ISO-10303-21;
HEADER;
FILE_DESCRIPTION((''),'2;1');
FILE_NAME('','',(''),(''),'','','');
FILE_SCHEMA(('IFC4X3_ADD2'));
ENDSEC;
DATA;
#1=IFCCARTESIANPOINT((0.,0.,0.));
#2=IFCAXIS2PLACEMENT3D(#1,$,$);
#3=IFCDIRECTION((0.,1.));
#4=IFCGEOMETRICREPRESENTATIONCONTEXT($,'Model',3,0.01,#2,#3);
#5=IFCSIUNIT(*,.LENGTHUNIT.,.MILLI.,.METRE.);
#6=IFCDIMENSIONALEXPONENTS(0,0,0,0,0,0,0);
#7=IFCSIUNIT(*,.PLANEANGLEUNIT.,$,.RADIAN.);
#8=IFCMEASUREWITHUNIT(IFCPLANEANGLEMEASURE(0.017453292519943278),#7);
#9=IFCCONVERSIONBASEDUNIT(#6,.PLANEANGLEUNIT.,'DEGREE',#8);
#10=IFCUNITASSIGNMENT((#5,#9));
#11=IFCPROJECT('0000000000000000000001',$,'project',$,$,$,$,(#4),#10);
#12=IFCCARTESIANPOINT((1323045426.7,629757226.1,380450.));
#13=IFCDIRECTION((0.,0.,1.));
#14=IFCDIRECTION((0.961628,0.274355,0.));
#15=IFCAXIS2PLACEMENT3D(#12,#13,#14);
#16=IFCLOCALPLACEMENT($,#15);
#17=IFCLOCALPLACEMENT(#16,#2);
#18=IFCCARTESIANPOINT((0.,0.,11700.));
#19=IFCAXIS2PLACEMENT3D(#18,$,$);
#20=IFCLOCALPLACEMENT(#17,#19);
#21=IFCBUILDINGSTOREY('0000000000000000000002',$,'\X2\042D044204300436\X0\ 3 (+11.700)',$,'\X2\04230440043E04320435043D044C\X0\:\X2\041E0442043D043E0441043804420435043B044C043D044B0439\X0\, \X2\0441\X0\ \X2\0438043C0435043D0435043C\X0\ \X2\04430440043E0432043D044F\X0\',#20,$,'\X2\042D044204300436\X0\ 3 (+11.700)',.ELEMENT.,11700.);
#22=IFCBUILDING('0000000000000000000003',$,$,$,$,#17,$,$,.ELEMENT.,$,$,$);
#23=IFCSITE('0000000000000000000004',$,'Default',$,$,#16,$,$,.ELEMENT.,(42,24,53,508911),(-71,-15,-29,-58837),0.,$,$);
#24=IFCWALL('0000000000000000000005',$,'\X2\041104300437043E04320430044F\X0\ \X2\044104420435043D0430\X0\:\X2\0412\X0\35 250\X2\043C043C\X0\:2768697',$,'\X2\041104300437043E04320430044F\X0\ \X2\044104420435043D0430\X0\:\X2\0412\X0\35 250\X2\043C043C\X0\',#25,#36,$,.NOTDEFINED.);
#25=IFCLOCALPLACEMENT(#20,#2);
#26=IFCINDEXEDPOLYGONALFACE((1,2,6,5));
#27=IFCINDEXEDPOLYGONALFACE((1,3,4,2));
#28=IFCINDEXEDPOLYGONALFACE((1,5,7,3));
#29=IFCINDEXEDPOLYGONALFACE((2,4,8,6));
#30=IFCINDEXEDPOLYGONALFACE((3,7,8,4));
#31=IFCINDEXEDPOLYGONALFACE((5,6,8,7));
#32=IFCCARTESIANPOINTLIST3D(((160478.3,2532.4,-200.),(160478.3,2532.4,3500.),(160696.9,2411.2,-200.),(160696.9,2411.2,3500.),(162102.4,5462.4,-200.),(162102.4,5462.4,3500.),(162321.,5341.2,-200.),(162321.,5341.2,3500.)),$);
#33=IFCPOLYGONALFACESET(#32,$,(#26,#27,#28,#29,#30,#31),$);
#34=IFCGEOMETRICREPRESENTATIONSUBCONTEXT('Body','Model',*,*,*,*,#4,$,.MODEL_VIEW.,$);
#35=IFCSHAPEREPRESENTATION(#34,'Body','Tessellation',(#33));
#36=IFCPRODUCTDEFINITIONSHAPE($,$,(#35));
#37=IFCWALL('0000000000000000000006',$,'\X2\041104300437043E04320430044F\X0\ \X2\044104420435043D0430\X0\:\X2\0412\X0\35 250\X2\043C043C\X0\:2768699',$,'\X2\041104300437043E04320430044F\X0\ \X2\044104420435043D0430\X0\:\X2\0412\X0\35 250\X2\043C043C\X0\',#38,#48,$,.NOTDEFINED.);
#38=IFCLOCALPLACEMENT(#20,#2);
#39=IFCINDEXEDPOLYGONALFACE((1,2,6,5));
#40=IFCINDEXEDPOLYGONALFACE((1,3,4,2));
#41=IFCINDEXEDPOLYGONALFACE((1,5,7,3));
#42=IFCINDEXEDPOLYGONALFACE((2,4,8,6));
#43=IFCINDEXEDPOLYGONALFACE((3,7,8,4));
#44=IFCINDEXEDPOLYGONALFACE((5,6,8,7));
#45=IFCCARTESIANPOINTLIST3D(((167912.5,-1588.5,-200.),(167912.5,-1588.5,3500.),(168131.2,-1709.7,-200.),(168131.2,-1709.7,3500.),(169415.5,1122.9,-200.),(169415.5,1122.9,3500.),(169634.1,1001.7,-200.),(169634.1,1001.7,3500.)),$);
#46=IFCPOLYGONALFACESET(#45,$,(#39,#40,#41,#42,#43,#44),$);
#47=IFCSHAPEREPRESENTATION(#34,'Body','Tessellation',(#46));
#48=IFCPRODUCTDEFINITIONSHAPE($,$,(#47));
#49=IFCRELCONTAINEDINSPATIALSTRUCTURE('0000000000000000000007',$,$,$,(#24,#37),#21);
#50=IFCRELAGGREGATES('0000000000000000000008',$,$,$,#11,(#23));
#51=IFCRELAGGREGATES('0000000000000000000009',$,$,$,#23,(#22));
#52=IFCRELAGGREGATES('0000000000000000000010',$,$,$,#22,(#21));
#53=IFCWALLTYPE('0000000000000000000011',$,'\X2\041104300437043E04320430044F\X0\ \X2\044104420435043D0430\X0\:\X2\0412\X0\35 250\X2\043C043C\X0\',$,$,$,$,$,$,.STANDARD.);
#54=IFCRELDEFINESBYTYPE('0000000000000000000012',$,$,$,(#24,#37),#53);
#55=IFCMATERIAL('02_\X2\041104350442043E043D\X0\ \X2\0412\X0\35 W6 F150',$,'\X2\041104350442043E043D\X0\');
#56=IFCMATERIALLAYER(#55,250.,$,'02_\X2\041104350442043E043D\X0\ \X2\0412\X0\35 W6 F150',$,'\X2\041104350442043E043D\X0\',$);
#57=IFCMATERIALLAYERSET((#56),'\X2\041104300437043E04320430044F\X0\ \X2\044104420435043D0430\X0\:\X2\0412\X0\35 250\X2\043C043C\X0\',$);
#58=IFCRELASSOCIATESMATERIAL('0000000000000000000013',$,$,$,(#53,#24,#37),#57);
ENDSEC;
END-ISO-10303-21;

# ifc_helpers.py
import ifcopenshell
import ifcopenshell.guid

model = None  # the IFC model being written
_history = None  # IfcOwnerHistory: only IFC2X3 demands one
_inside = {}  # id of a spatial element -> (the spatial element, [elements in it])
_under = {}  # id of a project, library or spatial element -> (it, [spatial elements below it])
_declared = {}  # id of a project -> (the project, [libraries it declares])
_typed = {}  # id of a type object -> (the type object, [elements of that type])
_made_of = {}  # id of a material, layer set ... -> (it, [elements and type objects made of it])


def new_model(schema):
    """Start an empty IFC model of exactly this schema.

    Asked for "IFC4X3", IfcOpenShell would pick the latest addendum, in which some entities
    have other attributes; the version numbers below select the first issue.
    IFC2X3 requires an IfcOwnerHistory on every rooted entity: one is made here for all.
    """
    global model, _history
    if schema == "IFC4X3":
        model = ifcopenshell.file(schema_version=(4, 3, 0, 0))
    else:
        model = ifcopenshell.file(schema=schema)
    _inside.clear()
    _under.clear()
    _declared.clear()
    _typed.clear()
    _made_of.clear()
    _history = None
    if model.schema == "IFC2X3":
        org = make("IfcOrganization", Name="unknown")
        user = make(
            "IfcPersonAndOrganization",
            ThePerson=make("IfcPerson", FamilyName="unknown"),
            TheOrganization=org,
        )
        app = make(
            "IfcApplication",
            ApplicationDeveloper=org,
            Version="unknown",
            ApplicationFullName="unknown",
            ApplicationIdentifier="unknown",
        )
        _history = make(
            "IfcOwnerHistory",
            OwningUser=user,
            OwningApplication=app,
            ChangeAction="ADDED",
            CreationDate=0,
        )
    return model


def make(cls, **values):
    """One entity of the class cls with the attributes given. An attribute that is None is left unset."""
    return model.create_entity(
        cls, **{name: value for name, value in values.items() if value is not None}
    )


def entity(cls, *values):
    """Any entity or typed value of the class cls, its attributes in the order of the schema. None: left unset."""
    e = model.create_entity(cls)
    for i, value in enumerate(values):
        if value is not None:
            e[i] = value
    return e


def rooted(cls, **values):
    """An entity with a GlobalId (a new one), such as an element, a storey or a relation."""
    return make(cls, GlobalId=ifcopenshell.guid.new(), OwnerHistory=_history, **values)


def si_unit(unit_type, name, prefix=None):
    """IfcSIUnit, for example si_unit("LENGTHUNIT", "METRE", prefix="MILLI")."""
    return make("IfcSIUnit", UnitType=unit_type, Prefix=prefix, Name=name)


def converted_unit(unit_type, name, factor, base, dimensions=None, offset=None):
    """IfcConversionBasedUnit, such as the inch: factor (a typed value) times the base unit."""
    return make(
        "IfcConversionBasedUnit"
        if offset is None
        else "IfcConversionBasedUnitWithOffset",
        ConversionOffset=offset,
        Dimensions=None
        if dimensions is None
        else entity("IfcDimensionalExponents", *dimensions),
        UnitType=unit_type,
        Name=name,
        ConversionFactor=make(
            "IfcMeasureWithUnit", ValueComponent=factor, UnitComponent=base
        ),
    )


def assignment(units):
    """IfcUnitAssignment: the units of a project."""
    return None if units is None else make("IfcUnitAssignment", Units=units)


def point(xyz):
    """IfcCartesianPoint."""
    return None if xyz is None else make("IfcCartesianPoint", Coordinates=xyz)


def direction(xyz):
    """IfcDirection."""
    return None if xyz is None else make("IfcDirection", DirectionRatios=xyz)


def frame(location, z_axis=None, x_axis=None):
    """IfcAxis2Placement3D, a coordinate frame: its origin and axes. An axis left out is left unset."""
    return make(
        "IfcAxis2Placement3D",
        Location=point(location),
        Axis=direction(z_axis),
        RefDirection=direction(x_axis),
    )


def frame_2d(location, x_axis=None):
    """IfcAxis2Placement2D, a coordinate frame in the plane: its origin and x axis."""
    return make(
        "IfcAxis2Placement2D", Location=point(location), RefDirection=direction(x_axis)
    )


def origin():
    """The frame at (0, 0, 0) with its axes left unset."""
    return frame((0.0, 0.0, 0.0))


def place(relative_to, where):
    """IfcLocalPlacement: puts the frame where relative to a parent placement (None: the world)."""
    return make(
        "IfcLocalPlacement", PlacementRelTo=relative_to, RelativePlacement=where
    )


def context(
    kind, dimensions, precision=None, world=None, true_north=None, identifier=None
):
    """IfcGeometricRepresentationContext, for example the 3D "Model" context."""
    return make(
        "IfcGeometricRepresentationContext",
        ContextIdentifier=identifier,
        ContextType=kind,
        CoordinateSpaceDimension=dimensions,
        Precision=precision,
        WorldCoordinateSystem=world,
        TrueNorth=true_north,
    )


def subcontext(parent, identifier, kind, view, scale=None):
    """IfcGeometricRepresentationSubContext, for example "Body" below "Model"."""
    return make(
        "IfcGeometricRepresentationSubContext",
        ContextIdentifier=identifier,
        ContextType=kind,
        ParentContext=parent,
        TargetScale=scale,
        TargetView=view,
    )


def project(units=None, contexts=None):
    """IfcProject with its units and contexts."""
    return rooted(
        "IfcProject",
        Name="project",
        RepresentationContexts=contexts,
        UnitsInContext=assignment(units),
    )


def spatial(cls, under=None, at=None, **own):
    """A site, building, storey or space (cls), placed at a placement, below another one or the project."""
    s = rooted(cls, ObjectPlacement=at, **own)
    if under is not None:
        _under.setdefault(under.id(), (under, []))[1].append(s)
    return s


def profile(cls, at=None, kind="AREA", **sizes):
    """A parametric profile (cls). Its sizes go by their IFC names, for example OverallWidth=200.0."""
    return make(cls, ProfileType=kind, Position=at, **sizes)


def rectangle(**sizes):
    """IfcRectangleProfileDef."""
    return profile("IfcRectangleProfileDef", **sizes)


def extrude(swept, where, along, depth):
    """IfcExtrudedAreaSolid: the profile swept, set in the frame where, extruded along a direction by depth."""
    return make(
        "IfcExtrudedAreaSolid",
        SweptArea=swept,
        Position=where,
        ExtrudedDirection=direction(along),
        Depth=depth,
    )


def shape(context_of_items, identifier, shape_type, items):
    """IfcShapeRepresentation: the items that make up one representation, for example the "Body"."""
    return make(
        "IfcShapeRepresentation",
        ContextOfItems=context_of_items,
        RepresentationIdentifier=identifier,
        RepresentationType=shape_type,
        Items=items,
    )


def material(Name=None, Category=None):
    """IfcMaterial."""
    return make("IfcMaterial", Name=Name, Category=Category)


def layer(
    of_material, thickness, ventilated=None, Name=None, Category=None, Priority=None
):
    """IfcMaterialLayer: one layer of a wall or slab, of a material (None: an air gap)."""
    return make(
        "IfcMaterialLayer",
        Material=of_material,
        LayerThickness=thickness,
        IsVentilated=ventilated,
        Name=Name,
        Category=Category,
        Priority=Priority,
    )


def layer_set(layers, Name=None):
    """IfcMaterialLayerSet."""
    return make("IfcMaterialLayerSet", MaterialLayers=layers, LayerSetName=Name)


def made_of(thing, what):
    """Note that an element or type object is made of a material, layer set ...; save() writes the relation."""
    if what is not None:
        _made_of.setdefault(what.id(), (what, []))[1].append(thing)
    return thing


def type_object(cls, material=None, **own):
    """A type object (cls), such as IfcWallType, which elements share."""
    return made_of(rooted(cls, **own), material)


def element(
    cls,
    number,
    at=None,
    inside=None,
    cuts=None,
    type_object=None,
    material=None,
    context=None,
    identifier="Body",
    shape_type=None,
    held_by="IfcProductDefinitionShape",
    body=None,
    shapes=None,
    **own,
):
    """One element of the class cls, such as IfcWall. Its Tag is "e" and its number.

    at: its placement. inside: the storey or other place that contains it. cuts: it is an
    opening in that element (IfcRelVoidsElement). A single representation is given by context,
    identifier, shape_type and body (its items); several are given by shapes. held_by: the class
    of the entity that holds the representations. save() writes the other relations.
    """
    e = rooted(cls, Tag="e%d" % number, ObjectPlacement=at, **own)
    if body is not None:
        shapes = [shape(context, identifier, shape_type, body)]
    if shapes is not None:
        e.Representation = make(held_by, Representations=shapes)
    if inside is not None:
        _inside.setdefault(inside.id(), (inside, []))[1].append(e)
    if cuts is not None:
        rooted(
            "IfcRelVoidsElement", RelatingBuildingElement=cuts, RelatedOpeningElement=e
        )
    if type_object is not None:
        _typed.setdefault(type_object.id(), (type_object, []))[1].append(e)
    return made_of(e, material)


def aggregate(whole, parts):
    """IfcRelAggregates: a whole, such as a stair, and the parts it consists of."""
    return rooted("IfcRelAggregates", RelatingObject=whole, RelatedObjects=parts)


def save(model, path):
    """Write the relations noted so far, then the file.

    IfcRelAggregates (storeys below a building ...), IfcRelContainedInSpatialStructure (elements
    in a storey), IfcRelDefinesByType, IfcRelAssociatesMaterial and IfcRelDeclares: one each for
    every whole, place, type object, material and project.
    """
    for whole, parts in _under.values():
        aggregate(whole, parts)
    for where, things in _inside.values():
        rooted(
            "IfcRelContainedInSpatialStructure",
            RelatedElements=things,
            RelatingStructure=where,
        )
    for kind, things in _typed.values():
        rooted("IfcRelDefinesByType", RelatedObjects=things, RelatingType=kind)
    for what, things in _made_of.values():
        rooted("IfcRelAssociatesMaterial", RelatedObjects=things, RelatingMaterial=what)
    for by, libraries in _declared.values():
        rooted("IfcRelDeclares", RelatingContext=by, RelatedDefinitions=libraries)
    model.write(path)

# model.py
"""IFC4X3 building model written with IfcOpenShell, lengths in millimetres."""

from ifc_helpers import new_model, entity, si_unit, converted_unit, direction, frame, frame_2d, origin, place, context, subcontext, project, spatial, rectangle, extrude, material, layer, layer_set, type_object, element, save


model = new_model("IFC4X3")

# Units and contexts
model_context = context("Model", 3, precision=0.01, world=origin(), true_north=direction((0.0, 1.0)))
body_context = subcontext(model_context, "Body", "Model", "MODEL_VIEW")
ifc_project = project(units=[si_unit("LENGTHUNIT", "METRE", prefix="MILLI"), converted_unit("PLANEANGLEUNIT", "DEGREE", entity("IfcPlaneAngleMeasure", 0.017453292519943278), si_unit("PLANEANGLEUNIT", "RADIAN"), dimensions=[0, 0, 0, 0, 0, 0, 0])], contexts=[model_context])

# Site, building, storey
site_placement = place(None, frame((1323045426.7, 629757226.1, 380450.0), z_axis=(0.0, 0.0, 1.0), x_axis=(0.961628, 0.274355, 0.0)))
site = spatial("IfcSite", under=ifc_project, at=site_placement, Name="Default", CompositionType="ELEMENT", RefLatitude=(42, 24, 53, 508911), RefLongitude=(-71, -15, -29, -58837), RefElevation=0.0)
building_placement = place(site_placement, origin())
building = spatial("IfcBuilding", under=site, at=building_placement, CompositionType="ELEMENT")
storey_placement = place(building_placement, frame((0.0, 0.0, 11700.0)))
storey = spatial("IfcBuildingStorey", under=building, at=storey_placement, Name="Этаж 3 (+11.700)", ObjectType="Уровень:Относительный, с именем уровня", LongName="Этаж 3 (+11.700)", CompositionType="ELEMENT", Elevation=11700.0)

# Shared definitions
ifc_material_1 = material(Name="02_Бетон В35 W6 F150", Category="Бетон")

# Shared definitions
ifc_layer = layer(ifc_material_1, 250.0, Name="02_Бетон В35 W6 F150", Category="Бетон")
ifc_layer_set = layer_set([ifc_layer], Name="Базовая стена:В35 250мм")
wall_type = type_object("IfcWallType", Name="Базовая стена:В35 250мм", PredefinedType="STANDARD", material=ifc_layer_set)

# Walls
wall_1_placement = place(storey_placement, frame((160587.6, 2471.8, -200.0), z_axis=(0.0, 0.0, 1.0), x_axis=(0.48481, 0.87462, 0.0)))
element("IfcWall", 1, at=wall_1_placement, inside=storey, type_object=wall_type, material=ifc_layer_set, Name="Базовая стена:В35 250мм:2768697", ObjectType="Базовая стена:В35 250мм", PredefinedType="NOTDEFINED", context=body_context, shape_type="SweptSolid", body=[
    extrude(rectangle(XDim=3350.0, YDim=250.0, at=frame_2d((1675.0, 0.0), x_axis=(-1.0, 0.0))), origin(), (0.0, 0.0, 1.0), 3700.0),
])
wall_2_placement = place(storey_placement, frame((168021.9, -1649.1, -200.0), z_axis=(0.0, 0.0, 1.0), x_axis=(0.48481, 0.87462, 0.0)))
element("IfcWall", 2, at=wall_2_placement, inside=storey, type_object=wall_type, material=ifc_layer_set, Name="Базовая стена:В35 250мм:2768699", ObjectType="Базовая стена:В35 250мм", PredefinedType="NOTDEFINED", context=body_context, shape_type="SweptSolid", body=[
    extrude(rectangle(XDim=3100.0, YDim=250.0, at=frame_2d((1550.0, 0.0), x_axis=(-1.0, 0.0))), origin(), (0.0, 0.0, 1.0), 3700.0),
])

save(model, "model.ifc")
